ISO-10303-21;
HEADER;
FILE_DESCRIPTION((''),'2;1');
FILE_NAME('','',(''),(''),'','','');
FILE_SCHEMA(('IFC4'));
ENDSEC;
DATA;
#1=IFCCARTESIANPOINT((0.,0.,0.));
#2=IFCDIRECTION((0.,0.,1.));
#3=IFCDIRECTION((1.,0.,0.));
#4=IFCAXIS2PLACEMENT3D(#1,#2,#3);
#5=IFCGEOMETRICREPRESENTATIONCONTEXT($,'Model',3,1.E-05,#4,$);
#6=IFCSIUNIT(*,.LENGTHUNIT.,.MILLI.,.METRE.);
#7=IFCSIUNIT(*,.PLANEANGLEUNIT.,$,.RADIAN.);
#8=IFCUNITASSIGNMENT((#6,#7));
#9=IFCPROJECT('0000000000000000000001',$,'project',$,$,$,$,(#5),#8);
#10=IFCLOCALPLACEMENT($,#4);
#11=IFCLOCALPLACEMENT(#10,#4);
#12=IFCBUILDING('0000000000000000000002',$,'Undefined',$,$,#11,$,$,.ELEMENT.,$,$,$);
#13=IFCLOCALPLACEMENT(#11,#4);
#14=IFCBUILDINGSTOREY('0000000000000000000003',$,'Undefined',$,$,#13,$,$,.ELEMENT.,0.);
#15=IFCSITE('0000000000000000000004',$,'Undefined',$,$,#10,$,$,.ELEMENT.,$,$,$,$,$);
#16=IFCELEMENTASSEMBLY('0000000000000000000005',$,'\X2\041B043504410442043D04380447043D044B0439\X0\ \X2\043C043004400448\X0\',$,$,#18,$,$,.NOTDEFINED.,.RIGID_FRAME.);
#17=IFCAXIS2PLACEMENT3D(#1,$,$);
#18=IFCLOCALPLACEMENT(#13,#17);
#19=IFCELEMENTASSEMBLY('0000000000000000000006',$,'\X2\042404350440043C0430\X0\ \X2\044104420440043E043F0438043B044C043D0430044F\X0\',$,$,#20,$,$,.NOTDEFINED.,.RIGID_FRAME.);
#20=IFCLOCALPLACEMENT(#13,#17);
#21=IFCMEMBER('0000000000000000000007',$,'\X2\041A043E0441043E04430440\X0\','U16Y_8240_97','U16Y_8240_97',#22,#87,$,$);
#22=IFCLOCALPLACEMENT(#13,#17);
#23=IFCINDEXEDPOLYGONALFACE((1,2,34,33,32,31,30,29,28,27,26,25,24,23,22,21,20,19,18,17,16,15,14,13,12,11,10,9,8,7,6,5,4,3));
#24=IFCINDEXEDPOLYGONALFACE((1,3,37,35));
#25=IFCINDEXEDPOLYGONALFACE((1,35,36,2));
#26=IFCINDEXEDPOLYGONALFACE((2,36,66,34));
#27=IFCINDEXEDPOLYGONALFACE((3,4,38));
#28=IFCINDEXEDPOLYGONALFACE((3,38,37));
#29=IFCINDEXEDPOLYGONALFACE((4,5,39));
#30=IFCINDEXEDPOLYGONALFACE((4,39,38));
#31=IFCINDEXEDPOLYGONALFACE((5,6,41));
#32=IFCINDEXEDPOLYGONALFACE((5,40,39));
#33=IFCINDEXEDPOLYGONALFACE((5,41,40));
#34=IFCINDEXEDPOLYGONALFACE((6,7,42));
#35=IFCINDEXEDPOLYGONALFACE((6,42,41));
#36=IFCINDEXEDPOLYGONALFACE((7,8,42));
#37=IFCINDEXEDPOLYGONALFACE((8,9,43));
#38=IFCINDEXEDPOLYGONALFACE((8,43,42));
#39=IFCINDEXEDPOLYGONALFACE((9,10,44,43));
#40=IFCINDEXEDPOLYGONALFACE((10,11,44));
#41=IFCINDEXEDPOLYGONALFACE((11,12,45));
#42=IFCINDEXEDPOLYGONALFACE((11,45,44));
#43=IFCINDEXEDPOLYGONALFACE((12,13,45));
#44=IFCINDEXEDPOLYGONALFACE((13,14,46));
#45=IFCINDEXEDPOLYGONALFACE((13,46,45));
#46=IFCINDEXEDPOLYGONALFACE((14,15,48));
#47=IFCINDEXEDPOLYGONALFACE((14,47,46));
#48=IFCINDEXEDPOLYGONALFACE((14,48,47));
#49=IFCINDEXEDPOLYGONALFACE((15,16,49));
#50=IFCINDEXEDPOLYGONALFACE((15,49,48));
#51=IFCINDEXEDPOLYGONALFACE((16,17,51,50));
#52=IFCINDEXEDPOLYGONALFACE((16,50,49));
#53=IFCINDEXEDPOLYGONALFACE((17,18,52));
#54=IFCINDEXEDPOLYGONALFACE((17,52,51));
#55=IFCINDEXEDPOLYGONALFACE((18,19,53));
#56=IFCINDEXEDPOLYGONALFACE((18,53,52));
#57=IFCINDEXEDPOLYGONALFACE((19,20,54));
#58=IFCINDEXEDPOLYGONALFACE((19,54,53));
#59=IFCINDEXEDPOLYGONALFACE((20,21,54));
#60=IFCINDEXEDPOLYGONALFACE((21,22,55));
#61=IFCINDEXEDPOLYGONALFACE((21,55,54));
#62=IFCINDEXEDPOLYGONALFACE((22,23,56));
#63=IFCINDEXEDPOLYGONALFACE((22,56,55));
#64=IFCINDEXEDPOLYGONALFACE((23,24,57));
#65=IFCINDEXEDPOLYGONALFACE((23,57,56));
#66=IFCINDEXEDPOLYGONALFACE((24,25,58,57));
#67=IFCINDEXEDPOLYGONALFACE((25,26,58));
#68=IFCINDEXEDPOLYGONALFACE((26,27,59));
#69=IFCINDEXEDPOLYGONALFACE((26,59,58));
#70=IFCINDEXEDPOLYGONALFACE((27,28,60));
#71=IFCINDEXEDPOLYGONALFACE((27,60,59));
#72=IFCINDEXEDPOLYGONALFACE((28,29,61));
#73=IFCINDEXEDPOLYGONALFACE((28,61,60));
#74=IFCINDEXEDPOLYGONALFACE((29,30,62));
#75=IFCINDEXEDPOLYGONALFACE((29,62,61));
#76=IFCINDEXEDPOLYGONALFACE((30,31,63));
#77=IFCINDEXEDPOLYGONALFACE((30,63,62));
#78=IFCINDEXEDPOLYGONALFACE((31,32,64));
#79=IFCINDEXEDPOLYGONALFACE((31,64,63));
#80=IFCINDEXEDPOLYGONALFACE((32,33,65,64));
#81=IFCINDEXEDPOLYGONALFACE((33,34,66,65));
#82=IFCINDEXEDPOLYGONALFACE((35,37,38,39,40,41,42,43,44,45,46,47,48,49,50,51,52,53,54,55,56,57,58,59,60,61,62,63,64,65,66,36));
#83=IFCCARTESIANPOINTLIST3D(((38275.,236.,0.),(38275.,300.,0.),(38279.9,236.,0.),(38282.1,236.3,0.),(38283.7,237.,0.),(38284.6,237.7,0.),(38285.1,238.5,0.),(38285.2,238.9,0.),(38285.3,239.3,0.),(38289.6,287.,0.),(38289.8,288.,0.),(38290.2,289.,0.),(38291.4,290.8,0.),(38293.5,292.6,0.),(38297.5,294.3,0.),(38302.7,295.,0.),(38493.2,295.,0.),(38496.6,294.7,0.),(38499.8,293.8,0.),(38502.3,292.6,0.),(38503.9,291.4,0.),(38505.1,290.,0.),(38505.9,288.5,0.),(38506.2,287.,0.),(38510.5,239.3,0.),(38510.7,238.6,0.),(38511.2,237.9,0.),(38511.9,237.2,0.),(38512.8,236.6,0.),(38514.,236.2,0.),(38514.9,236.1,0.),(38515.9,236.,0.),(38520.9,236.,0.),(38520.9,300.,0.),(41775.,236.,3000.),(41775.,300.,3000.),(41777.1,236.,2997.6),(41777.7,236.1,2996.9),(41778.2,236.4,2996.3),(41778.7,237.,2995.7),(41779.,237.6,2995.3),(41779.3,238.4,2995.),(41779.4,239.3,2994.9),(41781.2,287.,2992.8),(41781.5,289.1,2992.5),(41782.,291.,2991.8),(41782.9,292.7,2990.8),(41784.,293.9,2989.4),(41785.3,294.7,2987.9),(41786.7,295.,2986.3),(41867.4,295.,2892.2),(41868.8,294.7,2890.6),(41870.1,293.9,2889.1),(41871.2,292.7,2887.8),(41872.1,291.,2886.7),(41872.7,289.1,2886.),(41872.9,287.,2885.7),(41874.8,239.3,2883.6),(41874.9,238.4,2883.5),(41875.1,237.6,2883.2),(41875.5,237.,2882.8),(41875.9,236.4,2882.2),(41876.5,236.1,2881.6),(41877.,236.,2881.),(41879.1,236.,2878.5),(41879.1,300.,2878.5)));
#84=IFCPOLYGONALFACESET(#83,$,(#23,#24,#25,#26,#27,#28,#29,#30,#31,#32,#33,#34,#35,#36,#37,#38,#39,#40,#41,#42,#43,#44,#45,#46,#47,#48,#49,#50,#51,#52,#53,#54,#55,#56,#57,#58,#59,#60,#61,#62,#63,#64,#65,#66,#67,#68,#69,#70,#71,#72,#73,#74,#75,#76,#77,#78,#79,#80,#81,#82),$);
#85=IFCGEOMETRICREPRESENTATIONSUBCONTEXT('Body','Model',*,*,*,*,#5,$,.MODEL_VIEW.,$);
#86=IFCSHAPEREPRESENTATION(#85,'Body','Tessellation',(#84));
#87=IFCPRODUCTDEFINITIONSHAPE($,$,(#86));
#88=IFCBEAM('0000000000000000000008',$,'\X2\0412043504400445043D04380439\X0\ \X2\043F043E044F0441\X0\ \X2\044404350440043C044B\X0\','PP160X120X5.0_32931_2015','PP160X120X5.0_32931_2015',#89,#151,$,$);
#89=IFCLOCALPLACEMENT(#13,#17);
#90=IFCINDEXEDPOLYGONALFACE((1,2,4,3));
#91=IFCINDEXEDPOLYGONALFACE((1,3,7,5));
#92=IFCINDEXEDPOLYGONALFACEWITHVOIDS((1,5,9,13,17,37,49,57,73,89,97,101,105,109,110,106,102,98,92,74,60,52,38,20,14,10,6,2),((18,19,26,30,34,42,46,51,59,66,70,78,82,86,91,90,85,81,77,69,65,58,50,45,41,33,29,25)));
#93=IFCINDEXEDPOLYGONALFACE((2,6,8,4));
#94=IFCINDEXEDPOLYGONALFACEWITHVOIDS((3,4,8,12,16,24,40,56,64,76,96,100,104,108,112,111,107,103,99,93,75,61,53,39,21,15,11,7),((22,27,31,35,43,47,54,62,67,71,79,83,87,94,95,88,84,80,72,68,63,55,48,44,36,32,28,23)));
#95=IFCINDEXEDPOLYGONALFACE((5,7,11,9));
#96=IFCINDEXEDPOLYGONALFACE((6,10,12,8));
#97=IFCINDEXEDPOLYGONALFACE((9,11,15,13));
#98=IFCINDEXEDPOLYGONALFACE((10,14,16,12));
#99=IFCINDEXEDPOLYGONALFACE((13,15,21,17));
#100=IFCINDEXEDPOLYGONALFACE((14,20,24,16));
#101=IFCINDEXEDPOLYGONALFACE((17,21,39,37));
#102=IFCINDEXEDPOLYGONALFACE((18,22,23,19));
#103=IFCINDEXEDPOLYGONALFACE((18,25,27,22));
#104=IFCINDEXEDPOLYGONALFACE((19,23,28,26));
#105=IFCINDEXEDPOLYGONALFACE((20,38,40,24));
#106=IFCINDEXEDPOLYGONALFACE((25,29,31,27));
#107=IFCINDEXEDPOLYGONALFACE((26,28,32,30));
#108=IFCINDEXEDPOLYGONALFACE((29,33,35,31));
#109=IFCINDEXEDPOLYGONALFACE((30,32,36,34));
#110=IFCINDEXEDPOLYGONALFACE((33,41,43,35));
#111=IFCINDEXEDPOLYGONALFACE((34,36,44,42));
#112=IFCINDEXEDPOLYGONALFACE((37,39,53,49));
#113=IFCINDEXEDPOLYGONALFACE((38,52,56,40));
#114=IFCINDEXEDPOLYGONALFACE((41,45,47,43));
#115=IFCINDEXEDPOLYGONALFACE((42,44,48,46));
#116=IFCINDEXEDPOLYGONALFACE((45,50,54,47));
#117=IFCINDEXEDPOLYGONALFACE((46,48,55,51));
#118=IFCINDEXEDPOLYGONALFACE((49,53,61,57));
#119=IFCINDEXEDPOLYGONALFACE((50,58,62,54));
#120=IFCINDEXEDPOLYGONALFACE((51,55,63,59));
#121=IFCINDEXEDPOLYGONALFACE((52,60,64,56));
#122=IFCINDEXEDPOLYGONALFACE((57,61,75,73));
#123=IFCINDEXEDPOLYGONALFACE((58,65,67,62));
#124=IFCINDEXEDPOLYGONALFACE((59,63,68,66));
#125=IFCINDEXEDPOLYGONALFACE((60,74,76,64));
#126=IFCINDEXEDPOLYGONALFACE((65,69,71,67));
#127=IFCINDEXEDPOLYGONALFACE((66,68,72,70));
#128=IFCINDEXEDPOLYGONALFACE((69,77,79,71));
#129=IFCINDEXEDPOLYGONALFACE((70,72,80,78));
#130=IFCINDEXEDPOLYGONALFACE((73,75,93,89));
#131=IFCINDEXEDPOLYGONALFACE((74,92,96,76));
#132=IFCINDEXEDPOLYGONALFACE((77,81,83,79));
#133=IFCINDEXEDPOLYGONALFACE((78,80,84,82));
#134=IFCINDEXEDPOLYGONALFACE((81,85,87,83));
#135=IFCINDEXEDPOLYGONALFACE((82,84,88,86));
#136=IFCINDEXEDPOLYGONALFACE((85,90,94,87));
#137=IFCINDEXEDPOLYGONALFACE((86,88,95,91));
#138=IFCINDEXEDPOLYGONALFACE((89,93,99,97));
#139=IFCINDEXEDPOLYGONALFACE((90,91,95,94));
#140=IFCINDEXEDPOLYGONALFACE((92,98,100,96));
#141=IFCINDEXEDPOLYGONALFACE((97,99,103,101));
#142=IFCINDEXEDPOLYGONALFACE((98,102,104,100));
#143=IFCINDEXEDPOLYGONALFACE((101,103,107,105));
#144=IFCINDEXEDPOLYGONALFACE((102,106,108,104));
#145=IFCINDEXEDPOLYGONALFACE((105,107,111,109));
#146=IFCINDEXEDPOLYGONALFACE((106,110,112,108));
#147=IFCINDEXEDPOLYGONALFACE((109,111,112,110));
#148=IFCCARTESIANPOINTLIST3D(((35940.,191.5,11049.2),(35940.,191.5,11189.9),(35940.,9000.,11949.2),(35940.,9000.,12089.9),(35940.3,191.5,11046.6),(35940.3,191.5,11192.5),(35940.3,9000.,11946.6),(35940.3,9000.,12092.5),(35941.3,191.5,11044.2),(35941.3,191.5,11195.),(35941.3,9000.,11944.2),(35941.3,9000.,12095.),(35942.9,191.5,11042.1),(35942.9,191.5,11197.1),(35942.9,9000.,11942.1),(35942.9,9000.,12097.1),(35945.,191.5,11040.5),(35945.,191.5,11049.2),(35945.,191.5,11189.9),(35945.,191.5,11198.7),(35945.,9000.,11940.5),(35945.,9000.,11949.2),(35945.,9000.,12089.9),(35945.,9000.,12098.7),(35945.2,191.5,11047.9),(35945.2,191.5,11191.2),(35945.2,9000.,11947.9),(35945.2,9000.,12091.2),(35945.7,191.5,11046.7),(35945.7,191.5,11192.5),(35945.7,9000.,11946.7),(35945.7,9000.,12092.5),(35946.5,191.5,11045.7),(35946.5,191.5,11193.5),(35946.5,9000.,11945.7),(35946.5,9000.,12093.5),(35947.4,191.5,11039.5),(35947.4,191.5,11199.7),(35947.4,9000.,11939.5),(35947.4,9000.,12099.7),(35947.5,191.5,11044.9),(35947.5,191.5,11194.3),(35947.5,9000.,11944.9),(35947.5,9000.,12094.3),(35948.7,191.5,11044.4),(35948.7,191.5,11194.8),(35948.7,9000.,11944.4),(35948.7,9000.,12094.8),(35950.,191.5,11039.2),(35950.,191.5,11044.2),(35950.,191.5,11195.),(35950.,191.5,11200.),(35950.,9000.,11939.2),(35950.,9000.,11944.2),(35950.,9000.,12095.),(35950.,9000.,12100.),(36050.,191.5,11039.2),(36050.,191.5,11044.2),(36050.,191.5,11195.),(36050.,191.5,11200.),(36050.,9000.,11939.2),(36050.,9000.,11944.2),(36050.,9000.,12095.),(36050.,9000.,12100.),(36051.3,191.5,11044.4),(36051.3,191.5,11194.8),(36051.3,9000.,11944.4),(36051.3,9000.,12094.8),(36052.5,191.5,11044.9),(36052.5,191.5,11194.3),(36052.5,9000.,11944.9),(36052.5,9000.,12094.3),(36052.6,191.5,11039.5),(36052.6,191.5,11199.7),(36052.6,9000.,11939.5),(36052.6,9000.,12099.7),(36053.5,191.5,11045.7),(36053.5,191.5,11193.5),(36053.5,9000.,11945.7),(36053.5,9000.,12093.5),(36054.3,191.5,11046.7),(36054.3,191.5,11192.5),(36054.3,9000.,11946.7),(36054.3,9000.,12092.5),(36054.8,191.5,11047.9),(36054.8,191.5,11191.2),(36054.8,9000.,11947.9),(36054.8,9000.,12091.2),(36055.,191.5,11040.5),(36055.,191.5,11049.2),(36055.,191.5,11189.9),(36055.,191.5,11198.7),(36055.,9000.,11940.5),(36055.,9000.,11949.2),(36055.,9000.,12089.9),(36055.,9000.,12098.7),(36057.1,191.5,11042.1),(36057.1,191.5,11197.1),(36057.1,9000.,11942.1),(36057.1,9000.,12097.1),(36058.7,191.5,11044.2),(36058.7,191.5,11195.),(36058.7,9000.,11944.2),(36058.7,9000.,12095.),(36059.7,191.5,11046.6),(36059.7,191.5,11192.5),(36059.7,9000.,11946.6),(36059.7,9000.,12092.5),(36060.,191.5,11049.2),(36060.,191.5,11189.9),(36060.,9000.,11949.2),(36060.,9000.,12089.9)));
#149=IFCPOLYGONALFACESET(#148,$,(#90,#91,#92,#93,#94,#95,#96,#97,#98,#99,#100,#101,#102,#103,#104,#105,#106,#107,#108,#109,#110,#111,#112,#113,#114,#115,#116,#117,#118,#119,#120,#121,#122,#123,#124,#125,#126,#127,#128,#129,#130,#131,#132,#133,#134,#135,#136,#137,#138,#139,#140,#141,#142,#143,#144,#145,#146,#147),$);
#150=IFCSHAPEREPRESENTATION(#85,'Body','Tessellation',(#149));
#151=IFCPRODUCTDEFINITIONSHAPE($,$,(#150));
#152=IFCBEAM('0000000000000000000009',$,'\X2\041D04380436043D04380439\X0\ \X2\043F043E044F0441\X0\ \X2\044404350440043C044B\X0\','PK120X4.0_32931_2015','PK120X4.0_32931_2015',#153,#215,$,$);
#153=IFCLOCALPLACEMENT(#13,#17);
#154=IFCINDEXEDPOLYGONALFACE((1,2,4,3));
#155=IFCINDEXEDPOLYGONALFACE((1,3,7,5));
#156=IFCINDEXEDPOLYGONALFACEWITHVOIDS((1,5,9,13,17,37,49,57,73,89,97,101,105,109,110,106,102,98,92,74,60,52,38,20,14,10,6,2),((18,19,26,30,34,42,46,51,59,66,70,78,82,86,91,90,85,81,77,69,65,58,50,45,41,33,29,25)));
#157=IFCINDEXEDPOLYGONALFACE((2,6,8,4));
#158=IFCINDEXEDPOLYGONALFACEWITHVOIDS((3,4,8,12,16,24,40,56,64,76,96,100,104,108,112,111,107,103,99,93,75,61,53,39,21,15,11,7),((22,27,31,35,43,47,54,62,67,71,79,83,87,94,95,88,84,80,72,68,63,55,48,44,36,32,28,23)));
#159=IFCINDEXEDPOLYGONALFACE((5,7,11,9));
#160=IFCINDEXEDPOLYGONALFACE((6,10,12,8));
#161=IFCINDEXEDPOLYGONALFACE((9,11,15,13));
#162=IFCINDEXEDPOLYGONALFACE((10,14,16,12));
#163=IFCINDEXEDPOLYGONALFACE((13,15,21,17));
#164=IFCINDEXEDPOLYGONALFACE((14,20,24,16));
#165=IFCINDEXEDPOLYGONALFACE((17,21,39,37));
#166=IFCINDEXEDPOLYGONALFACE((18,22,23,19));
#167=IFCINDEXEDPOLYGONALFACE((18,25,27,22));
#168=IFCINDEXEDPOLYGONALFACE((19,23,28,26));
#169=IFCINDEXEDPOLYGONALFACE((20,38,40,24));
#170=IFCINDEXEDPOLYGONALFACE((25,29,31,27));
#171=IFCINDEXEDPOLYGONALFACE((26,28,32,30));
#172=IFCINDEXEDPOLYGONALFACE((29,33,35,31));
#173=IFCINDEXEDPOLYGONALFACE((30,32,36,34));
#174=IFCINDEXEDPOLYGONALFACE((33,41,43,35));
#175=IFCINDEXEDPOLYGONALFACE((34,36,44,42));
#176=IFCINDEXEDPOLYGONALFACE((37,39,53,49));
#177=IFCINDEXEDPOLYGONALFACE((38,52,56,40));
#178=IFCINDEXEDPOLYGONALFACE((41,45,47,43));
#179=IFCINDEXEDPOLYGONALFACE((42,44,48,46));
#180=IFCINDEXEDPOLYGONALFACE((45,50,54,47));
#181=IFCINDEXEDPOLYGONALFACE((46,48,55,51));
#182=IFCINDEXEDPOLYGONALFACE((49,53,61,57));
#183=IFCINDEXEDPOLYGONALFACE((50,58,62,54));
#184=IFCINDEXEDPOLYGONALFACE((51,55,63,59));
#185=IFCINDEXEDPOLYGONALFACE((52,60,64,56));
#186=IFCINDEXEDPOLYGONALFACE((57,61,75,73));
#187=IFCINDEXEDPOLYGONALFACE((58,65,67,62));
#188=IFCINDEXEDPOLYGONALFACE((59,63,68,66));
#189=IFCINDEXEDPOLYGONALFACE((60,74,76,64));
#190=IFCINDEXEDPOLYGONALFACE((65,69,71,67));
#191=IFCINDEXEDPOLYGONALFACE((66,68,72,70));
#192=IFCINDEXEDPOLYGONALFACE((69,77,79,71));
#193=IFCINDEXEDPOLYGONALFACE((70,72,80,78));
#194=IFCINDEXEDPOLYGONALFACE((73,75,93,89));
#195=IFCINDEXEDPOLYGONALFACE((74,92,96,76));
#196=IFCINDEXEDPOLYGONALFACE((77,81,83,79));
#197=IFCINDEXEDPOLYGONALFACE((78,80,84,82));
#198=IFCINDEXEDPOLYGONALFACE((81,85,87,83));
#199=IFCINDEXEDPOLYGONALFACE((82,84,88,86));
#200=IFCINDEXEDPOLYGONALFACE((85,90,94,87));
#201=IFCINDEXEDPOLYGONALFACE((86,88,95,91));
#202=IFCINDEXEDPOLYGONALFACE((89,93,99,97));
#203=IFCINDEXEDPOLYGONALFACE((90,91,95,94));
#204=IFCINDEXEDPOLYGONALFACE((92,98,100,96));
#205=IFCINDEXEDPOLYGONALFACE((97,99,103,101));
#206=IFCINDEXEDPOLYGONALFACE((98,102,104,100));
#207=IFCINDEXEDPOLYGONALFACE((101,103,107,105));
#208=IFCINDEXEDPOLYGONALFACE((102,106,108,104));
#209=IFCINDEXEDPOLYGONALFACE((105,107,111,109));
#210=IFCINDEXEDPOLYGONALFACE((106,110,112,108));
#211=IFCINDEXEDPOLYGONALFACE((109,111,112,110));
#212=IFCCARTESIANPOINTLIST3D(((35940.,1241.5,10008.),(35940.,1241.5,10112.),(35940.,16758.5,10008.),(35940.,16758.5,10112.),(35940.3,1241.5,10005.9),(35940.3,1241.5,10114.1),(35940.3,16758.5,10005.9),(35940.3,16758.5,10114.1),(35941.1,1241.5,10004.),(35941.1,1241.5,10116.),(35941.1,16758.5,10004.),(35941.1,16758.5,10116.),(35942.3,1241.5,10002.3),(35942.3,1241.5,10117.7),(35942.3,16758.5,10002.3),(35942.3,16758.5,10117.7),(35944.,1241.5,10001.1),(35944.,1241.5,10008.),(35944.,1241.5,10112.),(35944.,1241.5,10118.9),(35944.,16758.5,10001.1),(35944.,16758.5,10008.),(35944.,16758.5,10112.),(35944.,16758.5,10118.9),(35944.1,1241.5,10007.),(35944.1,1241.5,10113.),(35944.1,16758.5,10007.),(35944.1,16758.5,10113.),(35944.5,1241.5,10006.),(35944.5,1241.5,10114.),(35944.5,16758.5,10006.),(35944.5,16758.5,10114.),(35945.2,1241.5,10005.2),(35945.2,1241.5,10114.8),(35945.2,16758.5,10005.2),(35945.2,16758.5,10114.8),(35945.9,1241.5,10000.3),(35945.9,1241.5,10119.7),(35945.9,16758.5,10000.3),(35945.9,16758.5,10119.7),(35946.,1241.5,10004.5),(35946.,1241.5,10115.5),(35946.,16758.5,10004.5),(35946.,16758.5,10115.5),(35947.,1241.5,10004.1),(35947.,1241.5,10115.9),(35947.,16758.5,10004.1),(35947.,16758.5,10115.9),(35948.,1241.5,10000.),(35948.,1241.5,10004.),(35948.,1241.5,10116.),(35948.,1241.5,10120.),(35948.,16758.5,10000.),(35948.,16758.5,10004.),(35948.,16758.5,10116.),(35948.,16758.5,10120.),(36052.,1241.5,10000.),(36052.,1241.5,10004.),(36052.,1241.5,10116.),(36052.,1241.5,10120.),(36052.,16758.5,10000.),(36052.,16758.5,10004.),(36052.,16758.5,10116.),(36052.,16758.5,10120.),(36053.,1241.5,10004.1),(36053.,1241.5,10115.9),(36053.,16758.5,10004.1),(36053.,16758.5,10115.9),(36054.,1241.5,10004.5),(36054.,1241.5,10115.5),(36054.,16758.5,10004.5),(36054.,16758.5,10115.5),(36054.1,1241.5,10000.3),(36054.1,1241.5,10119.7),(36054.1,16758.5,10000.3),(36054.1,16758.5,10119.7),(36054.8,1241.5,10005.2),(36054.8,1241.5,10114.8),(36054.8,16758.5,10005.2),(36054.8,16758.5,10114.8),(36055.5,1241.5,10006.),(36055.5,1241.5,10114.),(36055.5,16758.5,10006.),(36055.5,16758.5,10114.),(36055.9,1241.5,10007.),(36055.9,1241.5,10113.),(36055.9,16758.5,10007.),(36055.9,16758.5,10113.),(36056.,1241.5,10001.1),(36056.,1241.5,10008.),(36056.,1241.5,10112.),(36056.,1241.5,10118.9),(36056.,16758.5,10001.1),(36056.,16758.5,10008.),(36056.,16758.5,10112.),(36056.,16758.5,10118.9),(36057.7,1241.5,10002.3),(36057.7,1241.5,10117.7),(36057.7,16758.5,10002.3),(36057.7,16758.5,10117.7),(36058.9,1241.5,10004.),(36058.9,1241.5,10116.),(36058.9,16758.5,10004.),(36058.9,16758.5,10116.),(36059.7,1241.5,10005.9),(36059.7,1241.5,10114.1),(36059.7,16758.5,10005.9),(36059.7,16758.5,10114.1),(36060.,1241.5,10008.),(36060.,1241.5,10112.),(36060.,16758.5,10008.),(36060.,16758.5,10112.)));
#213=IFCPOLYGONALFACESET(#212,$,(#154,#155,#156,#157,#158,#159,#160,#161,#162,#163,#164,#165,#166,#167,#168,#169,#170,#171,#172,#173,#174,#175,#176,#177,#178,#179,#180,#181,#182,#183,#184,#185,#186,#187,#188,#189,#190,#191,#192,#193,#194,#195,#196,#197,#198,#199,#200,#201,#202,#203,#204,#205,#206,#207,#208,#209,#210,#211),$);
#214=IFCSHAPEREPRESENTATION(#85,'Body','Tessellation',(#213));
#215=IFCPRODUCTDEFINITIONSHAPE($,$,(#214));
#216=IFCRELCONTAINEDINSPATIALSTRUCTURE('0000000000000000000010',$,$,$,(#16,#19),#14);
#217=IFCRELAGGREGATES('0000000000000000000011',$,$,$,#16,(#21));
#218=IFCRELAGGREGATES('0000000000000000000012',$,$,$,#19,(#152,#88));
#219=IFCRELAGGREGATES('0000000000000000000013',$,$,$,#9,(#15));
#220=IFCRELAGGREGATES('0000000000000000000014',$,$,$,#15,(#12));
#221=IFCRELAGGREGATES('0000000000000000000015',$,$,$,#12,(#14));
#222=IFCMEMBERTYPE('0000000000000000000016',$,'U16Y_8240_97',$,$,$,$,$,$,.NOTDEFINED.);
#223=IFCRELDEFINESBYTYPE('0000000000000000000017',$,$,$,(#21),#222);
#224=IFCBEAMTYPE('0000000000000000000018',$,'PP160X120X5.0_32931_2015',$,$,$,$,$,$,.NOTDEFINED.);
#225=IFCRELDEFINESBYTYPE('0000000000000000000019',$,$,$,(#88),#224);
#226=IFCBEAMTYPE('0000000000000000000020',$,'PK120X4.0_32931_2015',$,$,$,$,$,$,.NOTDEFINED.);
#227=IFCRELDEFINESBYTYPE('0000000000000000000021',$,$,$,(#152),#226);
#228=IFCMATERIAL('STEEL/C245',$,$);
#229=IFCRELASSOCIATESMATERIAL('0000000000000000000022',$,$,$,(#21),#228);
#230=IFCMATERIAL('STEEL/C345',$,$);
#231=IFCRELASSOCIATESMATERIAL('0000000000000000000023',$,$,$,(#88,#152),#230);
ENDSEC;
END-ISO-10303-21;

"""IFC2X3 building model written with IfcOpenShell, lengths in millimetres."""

from ifc_helpers import new_model, si_unit, frame, origin_with_axes, origin_2d_with_axis, place, context, subcontext, project, spatial, hollow_rectangle, u_section, extrude, clip, halfspace, material, type_object, element, aggregate, save


model = new_model("IFC2X3")

# Units and contexts
model_context = context("Model", 3, precision=1e-05, world=origin_with_axes())
body_context = subcontext(model_context, "Body", "Model", "MODEL_VIEW")
ifc_project = project(units=[si_unit("LENGTHUNIT", "METRE", prefix="MILLI"), si_unit("PLANEANGLEUNIT", "RADIAN")], contexts=[model_context])

# Site, building, storey
site_placement = place(None, origin_with_axes())
site = spatial("IfcSite", under=ifc_project, at=site_placement, Name="Undefined", CompositionType="ELEMENT")
building_placement = place(site_placement, origin_with_axes())
building = spatial("IfcBuilding", under=site, at=building_placement, Name="Undefined", CompositionType="ELEMENT")
storey_placement = place(building_placement, origin_with_axes())
storey = spatial("IfcBuildingStorey", under=building, at=storey_placement, Name="Undefined", CompositionType="ELEMENT", Elevation=0.0)

# Shared definitions
ifc_material_1 = material(Name="STEEL/C245")

# Element assembly
assembly_1_placement = place(storey_placement, origin_with_axes())
assembly_1 = element("IfcElementAssembly", 1, at=assembly_1_placement, inside=storey, Name="Лестничный марш", AssemblyPlace="NOTDEFINED", PredefinedType="RIGID_FRAME")

# Shared definitions
ifc_material_2 = material(Name="STEEL/C345")

# Element assembly
assembly_2_placement = place(storey_placement, origin_with_axes())
assembly_2 = element("IfcElementAssembly", 2, at=assembly_2_placement, inside=storey, Name="Ферма стропильная", AssemblyPlace="NOTDEFINED", PredefinedType="RIGID_FRAME")

# Member
member_type_1 = type_object("IfcMemberType", Name="U16Y_8240_97", PredefinedType="NOTDEFINED")
member_1_placement = place(assembly_1_placement, frame((38327.1, 268.0, -60.7), z_axis=(-0.650791, 0.0, 0.759257), x_axis=(0.759257, 0.0, 0.650791)))
member_1 = element("IfcMember", 3, at=member_1_placement, type_object=member_type_1, material=ifc_material_1, Name="Косоур", Description="U16Y_8240_97", ObjectType="U16Y_8240_97", context=body_context, shape_type="Clipping", body=[
    clip(extrude(u_section(Depth=160.0, FlangeWidth=64.0, WebThickness=5.0, FlangeThickness=8.4, FilletRadius=8.5, EdgeRadius=3.5, FlangeSlope=0.058932, at=origin_2d_with_axis()), frame((4609.8, 0.0, 0.0), z_axis=(-1.0, 0.0, 0.0), x_axis=(0.0, -1.0, 0.0)), (0.0, 0.0, 1.0), 4690.6), halfspace(frame((0.0, -1032.0, 80.0), z_axis=(0.650791, 0.0, 0.759257), x_axis=(-0.759257, 0.0, 0.650791)), True)),
])
aggregate(assembly_1, [member_1])

# Beams
beam_type_1 = type_object("IfcBeamType", Name="PP160X120X5.0_32931_2015", PredefinedType="NOTDEFINED")
beam_1_placement = place(assembly_2_placement, frame((36000.0, 199.6, 11120.4), z_axis=(0.0, -0.101645, 0.994821), x_axis=(0.0, 0.994821, 0.101645)))
beam_1 = element("IfcBeam", 4, at=beam_1_placement, type_object=beam_type_1, material=ifc_material_2, Name="Верхний пояс фермы", Description="PP160X120X5.0_32931_2015", ObjectType="PP160X120X5.0_32931_2015", context=body_context, shape_type="Clipping", body=[
    clip(clip(extrude(hollow_rectangle(XDim=120.0, YDim=160.0, WallThickness=5.0, InnerFilletRadius=5.0, OuterFilletRadius=10.0, at=origin_2d_with_axis()), frame((8862.7, 0.0, 0.0), z_axis=(-1.0, 0.0, 0.0), x_axis=(0.0, -1.0, 0.0)), (0.0, 0.0, 1.0), 8887.4), halfspace(frame((8854.4, 0.0, 80.0), z_axis=(0.994821, 0.0, -0.101645), x_axis=(0.0, -1.0, 0.0)), False)), halfspace(frame((0.0, 0.0, 80.0), z_axis=(0.994821, 0.0, -0.101645), x_axis=(0.0, -1.0, 0.0)), True)),
])
beam_type_2 = type_object("IfcBeamType", Name="PK120X4.0_32931_2015", PredefinedType="NOTDEFINED")
beam_2_placement = place(assembly_2_placement, frame((36000.0, 1241.5, 10060.0), z_axis=(0.0, 0.0, 1.0), x_axis=(0.0, 1.0, 0.0)))
beam_2 = element("IfcBeam", 5, at=beam_2_placement, type_object=beam_type_2, material=ifc_material_2, Name="Нижний пояс фермы", Description="PK120X4.0_32931_2015", ObjectType="PK120X4.0_32931_2015", context=body_context, shape_type="SweptSolid", body=[
    extrude(hollow_rectangle(XDim=120.0, YDim=120.0, WallThickness=4.0, InnerFilletRadius=4.0, OuterFilletRadius=8.0, at=origin_2d_with_axis()), frame((15517.0, 0.0, 0.0), z_axis=(-1.0, 0.0, 0.0), x_axis=(0.0, -1.0, 0.0)), (0.0, 0.0, 1.0), 15517.0),
])
aggregate(assembly_2, [beam_2, beam_1])

save(model, "model.ifc")
